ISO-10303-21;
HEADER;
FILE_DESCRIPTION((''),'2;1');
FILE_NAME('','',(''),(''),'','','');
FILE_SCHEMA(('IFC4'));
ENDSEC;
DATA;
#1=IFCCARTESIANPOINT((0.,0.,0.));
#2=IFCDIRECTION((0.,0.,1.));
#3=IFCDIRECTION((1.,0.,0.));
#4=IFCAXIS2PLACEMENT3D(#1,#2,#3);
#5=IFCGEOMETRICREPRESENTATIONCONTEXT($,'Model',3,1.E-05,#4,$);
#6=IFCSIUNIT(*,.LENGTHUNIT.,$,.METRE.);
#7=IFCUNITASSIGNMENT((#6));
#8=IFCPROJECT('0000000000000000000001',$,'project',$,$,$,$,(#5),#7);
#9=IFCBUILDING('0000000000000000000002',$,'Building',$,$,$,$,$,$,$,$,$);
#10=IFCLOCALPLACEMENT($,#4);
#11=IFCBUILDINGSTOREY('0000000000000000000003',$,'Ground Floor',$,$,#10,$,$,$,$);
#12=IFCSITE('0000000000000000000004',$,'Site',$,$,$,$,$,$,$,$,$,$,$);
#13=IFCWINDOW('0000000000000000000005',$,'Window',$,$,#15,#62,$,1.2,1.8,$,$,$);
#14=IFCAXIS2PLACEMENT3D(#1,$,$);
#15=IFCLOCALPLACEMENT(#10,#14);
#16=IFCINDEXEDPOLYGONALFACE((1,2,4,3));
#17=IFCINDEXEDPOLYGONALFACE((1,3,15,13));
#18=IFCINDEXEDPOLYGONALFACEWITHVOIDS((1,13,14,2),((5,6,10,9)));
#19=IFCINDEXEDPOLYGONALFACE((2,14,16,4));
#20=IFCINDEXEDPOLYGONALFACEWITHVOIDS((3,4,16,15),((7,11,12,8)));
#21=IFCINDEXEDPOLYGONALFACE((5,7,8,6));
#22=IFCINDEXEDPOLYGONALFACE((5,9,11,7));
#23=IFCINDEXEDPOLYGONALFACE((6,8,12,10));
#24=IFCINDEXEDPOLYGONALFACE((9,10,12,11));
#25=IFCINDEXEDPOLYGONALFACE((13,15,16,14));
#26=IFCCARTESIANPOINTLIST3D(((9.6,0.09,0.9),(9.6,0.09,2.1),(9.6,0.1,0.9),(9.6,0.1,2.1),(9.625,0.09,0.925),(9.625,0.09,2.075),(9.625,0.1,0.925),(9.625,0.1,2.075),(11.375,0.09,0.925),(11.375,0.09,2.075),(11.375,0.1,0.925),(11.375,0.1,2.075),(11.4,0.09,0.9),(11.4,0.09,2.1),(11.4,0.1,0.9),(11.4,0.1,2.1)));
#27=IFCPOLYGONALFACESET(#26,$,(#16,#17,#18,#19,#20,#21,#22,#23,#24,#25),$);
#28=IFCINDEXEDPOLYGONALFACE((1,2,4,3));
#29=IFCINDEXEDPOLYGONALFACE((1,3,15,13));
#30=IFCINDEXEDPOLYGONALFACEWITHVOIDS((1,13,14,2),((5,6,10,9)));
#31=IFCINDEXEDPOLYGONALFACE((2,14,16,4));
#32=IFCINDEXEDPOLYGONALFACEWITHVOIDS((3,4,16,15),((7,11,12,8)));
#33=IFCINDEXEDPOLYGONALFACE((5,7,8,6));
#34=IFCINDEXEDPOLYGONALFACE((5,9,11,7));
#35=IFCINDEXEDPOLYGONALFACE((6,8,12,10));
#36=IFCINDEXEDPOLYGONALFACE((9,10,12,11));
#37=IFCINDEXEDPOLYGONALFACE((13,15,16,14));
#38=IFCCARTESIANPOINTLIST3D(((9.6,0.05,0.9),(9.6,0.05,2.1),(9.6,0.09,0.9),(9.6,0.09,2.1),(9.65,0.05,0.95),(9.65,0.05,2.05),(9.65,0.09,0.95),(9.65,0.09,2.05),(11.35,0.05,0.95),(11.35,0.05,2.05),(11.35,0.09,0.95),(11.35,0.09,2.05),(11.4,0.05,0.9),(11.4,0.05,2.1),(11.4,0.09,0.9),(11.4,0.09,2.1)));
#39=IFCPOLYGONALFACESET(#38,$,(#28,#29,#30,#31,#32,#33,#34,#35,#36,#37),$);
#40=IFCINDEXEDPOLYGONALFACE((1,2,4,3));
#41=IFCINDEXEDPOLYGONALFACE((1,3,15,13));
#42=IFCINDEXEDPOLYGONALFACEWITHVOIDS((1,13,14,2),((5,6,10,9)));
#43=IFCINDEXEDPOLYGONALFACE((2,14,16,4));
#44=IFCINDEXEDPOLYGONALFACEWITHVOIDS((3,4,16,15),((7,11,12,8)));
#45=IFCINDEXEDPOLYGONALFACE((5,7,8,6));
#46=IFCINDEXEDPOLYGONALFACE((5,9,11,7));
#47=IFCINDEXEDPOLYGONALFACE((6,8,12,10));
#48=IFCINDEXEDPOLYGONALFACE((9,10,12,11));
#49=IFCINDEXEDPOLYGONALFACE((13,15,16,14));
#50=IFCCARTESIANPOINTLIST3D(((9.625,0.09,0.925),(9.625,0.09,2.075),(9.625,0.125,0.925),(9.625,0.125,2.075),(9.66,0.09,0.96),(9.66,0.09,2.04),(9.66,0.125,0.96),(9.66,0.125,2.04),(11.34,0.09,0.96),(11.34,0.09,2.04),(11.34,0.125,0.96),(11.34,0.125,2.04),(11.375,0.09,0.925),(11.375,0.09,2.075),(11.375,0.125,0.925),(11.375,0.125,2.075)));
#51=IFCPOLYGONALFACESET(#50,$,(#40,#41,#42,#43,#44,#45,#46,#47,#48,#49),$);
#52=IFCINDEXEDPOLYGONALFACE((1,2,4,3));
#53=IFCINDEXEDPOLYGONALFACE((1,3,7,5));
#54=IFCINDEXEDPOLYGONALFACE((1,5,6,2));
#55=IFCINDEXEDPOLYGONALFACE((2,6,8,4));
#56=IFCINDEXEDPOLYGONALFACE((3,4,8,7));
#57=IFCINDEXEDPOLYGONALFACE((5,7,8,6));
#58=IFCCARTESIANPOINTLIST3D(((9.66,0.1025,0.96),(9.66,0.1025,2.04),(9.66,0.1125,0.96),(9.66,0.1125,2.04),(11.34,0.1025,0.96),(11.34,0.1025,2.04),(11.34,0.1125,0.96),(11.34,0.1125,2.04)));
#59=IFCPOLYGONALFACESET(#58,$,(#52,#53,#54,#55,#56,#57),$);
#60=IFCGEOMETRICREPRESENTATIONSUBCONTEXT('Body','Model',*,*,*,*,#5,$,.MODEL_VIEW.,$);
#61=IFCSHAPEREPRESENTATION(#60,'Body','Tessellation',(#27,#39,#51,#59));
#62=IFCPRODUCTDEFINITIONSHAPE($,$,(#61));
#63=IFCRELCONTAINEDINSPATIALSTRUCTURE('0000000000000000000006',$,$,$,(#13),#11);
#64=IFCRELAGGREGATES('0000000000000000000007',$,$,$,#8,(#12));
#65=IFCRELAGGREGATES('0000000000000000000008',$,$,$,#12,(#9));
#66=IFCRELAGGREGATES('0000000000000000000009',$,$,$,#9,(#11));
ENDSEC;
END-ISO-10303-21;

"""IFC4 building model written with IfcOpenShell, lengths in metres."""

from ifc_helpers import new_model, si_unit, frame, origin_with_axes, place, context, subcontext, project, spatial, line, indexed_curve, outline, extrude, element, save


model = new_model("IFC4")

# Units and contexts
model_context = context("Model", 3, precision=1e-05, world=origin_with_axes())
body_context = subcontext(model_context, "Body", "Model", "MODEL_VIEW")
ifc_project = project(units=[si_unit("LENGTHUNIT", "METRE")], contexts=[model_context])

# Site, building, storey
site = spatial("IfcSite", under=ifc_project, Name="Site")
building = spatial("IfcBuilding", under=site, Name="Building")
storey_placement = place(None, origin_with_axes())
storey = spatial("IfcBuildingStorey", under=building, at=storey_placement, Name="Ground Floor")

# Window
for number, where, z_axis, x_axis, name in (
    (1, (9.6, 0.0, 0.9), (0.0, 0.0, 1.0), (1.0, 0.0, 0.0), "Window"),
):
    element("IfcWindow", number, at=place(storey_placement, frame(where, z_axis=z_axis, x_axis=x_axis)), inside=storey, Name=name, OverallHeight=1.2, OverallWidth=1.8, context=body_context, shape_type="SweptSolid", body=[
        extrude(outline(indexed_curve([(0.0, 0.0), (1.8, 0.0), (1.8, 1.2), (0.0, 1.2)], segments=[line(1, 2, 3, 4, 1)]), holes=[indexed_curve([(0.025, 0.025), (1.775, 0.025), (1.775, 1.175), (0.025, 1.175)], segments=[line(1, 2, 3, 4, 1)])]), frame((0.0, 0.09, 0.0), z_axis=(0.0, -1.0, 0.0), x_axis=(1.0, 0.0, 0.0)), (0.0, 0.0, -1.0), 0.01),
        extrude(outline(indexed_curve([(0.0, 0.0), (1.8, 0.0), (1.8, 1.2), (0.0, 1.2)], segments=[line(1, 2, 3, 4, 1)]), holes=[indexed_curve([(0.05, 0.05), (1.75, 0.05), (1.75, 1.15), (0.05, 1.15)], segments=[line(1, 2, 3, 4, 1)])]), frame((0.0, 0.05, 0.0), z_axis=(0.0, -1.0, 0.0), x_axis=(1.0, 0.0, 0.0)), (0.0, 0.0, -1.0), 0.04),
        extrude(outline(indexed_curve([(0.0, 0.0), (1.75, 0.0), (1.75, 1.15), (0.0, 1.15)], segments=[line(1, 2, 3, 4, 1)]), holes=[indexed_curve([(0.035, 0.035), (1.715, 0.035), (1.715, 1.115), (0.035, 1.115)], segments=[line(1, 2, 3, 4, 1)])]), frame((0.025, 0.09, 0.025), z_axis=(0.0, -1.0, 0.0), x_axis=(1.0, 0.0, 0.0)), (0.0, 0.0, -1.0), 0.035),
        extrude(outline(indexed_curve([(0.035, 0.035), (1.715, 0.035), (1.715, 1.115), (0.035, 1.115)], segments=[line(1, 2, 3, 4, 1)])), frame((0.025, 0.1025, 0.025), z_axis=(0.0, -1.0, 0.0), x_axis=(1.0, 0.0, 0.0)), (0.0, 0.0, -1.0), 0.01),
    ])

save(model, "model.ifc")
